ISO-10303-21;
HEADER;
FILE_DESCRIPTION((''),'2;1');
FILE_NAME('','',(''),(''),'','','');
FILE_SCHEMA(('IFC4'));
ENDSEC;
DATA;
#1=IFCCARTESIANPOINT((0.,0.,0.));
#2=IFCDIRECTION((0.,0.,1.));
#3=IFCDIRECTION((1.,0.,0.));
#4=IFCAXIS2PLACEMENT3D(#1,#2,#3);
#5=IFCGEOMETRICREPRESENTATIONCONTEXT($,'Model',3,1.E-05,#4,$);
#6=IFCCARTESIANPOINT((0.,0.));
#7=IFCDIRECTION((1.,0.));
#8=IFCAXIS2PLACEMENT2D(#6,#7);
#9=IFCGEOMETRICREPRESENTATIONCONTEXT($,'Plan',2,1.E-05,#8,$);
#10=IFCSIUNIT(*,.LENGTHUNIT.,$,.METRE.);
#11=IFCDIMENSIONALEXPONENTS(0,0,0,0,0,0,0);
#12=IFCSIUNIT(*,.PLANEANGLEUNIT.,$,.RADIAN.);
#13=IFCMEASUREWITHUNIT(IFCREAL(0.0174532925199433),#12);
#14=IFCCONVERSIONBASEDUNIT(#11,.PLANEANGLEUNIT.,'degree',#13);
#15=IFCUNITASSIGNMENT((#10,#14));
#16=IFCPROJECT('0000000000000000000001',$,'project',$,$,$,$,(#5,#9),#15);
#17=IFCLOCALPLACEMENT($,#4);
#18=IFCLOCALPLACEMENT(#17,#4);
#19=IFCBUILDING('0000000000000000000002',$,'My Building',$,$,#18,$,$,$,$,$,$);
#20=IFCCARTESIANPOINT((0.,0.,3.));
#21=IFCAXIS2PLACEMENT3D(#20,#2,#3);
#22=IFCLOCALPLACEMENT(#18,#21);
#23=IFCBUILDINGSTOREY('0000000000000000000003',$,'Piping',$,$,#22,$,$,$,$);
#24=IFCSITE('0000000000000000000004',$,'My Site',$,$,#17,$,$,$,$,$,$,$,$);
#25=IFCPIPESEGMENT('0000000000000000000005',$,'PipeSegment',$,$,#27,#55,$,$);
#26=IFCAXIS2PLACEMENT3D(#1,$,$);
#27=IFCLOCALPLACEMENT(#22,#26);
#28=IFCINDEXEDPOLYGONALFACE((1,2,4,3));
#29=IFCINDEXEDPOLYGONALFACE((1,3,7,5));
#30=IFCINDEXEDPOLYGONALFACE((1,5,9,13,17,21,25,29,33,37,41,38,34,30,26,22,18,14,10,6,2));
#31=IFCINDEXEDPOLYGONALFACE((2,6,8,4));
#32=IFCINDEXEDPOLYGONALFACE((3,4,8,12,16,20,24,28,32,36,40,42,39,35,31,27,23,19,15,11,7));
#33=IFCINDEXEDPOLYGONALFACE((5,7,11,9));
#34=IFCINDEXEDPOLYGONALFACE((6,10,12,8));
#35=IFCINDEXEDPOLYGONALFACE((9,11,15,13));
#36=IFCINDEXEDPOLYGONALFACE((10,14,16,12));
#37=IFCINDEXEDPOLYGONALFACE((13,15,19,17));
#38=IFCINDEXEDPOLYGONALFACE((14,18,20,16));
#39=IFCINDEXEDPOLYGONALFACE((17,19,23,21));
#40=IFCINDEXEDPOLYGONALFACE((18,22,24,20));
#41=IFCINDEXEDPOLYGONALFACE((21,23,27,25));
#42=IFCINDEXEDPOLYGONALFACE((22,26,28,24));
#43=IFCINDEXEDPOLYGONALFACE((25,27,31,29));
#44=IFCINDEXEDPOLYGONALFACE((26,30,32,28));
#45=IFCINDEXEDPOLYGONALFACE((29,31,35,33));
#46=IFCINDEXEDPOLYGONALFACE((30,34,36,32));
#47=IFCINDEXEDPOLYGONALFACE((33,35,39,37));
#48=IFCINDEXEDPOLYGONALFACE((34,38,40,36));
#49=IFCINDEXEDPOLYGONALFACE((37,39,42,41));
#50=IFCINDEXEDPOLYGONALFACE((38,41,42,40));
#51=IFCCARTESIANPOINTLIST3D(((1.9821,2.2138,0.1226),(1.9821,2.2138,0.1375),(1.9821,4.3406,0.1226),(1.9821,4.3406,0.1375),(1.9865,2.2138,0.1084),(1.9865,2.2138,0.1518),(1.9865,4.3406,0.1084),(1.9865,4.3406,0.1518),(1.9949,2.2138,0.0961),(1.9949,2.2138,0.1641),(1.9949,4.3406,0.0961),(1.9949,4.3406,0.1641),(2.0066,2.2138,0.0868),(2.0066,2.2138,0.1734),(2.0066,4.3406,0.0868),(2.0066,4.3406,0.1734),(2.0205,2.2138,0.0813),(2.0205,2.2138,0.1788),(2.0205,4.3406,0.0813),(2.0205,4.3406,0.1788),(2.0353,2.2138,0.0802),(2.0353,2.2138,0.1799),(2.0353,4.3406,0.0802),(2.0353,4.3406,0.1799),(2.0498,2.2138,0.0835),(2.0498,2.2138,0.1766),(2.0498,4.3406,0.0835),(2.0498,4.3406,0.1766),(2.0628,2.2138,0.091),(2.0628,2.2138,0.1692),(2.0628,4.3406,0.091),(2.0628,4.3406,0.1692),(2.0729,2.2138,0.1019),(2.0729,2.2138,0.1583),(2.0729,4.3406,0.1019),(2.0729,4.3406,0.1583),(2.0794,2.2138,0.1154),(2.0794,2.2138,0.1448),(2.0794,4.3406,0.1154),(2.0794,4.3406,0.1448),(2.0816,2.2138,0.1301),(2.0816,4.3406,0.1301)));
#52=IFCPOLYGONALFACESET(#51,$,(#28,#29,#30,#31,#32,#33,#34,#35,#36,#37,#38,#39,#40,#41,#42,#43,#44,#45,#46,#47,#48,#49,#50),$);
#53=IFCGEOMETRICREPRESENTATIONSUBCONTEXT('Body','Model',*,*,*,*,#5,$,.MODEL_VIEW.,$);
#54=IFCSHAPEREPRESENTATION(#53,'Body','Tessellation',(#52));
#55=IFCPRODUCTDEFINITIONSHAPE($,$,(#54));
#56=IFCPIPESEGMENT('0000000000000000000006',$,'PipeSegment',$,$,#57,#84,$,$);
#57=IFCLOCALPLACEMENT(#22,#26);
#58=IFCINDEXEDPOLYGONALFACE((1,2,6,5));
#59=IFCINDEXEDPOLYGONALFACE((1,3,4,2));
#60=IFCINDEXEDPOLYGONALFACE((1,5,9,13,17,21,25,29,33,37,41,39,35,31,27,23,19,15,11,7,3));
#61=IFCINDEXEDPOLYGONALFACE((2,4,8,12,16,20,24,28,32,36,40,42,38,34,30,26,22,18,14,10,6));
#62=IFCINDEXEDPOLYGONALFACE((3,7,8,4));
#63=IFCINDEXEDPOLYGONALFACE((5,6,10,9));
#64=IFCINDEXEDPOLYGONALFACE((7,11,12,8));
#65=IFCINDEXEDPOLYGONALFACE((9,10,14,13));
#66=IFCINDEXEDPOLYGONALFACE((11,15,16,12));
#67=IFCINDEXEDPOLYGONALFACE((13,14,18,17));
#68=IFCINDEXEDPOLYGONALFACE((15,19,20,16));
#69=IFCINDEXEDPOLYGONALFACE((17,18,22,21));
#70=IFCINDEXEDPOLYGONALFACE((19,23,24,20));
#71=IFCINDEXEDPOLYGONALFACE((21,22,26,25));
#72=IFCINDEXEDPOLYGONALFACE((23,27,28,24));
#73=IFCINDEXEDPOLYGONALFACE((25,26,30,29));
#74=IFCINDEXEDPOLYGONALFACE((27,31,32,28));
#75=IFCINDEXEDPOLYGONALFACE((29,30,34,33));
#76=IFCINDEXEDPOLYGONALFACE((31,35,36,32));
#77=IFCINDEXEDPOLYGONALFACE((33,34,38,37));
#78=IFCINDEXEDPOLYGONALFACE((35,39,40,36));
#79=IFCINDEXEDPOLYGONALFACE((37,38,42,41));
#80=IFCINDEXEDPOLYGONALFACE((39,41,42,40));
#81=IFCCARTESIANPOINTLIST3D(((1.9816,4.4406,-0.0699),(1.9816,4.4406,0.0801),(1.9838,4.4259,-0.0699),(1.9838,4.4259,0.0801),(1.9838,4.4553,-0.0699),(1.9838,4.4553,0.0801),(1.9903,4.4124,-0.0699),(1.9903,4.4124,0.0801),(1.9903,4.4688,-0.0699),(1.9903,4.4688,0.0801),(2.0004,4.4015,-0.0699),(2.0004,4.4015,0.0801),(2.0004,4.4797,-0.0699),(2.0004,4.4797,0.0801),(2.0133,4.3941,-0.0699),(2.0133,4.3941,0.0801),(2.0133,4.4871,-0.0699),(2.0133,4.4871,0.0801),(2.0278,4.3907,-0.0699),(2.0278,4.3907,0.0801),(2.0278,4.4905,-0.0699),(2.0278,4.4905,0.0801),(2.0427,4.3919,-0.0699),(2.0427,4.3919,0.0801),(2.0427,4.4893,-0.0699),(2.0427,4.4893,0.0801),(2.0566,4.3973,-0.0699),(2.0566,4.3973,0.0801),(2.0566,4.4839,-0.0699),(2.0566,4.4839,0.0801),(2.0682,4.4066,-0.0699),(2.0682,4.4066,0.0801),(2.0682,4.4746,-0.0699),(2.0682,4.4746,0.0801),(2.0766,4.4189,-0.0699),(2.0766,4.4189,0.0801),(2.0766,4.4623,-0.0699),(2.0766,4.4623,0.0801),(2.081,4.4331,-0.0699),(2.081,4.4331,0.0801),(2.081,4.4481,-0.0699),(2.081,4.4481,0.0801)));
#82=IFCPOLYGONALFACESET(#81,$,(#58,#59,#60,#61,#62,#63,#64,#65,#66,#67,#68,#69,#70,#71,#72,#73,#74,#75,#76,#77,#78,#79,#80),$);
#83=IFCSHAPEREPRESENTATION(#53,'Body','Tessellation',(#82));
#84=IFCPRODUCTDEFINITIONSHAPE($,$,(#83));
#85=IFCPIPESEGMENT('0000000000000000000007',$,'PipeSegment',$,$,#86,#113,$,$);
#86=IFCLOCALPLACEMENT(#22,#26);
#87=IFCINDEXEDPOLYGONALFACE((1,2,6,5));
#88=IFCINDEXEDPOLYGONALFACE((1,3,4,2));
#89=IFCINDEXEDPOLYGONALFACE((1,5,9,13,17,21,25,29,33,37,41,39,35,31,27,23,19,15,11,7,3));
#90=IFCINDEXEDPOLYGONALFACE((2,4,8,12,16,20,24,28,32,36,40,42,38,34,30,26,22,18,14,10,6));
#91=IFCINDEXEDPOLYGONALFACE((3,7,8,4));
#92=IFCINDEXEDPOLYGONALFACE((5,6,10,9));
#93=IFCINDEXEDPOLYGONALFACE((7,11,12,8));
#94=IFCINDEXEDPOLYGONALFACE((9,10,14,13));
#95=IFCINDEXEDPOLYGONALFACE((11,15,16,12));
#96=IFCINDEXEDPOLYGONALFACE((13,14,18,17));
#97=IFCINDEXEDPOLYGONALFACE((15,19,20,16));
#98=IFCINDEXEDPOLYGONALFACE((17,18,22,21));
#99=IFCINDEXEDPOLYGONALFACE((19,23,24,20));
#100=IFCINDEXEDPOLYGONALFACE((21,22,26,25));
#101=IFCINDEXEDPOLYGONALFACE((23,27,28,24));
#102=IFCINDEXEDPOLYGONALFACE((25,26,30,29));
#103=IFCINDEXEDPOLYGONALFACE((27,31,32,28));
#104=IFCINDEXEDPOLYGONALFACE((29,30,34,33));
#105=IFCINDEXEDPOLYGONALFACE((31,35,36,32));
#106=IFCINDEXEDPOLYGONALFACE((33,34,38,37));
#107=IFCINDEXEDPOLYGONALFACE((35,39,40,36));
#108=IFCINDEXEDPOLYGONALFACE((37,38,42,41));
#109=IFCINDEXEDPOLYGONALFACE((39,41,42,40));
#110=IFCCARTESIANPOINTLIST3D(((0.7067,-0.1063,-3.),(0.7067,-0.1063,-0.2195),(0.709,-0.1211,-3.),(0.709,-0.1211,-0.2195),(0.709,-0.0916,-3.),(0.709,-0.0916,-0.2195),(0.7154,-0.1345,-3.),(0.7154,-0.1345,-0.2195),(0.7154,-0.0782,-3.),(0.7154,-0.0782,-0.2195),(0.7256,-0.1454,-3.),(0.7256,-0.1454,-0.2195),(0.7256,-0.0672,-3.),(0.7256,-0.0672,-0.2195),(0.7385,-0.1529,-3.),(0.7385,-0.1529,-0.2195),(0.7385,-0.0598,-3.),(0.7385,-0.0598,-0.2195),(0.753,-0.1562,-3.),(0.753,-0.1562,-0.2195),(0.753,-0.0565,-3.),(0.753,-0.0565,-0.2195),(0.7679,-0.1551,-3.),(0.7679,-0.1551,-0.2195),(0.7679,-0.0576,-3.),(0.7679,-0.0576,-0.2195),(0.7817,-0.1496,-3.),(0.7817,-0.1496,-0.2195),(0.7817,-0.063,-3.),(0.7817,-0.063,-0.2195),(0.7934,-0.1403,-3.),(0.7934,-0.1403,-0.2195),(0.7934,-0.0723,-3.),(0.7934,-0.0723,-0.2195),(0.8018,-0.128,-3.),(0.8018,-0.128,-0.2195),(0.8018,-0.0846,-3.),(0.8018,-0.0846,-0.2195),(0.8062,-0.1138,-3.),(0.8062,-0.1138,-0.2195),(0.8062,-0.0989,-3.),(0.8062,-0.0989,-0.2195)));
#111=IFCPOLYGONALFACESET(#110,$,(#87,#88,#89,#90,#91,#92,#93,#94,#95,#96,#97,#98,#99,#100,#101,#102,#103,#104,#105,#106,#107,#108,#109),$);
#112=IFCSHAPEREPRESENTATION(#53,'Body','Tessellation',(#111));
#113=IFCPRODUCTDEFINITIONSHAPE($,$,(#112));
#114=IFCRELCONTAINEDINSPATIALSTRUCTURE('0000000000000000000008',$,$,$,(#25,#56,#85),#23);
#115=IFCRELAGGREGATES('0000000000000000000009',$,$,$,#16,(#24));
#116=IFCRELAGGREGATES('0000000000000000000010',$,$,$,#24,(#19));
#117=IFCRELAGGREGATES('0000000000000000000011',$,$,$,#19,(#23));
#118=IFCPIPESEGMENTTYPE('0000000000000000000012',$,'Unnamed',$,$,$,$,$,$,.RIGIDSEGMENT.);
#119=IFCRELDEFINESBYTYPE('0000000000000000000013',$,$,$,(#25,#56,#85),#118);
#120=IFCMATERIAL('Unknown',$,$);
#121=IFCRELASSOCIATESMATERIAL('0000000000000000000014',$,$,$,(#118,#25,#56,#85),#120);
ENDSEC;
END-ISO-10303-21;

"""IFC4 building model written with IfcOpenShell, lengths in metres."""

from ifc_helpers import new_model, entity, si_unit, converted_unit, frame, origin_with_axes, origin_2d_with_axis, place, context, subcontext, project, spatial, circle, extrude, material, material_profile, profile_set, profile_usage, type_object, element, save


model = new_model("IFC4")

# Units and contexts
model_context = context("Model", 3, precision=1e-05, world=origin_with_axes())
plan_context = context("Plan", 2, precision=1e-05, world=origin_2d_with_axis())
body_context = subcontext(model_context, "Body", "Model", "MODEL_VIEW")
ifc_project = project(units=[si_unit("LENGTHUNIT", "METRE"), converted_unit("PLANEANGLEUNIT", "degree", entity("IfcReal", 0.0174532925199433), si_unit("PLANEANGLEUNIT", "RADIAN"), dimensions=[0, 0, 0, 0, 0, 0, 0])], contexts=[model_context, plan_context])

# Site, building, storey
site_placement = place(None, origin_with_axes())
site = spatial("IfcSite", under=ifc_project, at=site_placement, Name="My Site")
building_placement = place(site_placement, origin_with_axes())
building = spatial("IfcBuilding", under=site, at=building_placement, Name="My Building")
storey_placement = place(building_placement, frame((0.0, 0.0, 3.0), z_axis=(0.0, 0.0, 1.0), x_axis=(1.0, 0.0, 0.0)))
storey = spatial("IfcBuildingStorey", under=building, at=storey_placement, Name="Piping")

# Pipe segments
ifc_material = material(Name="Unknown")
ifc_material_profile_1 = material_profile(ifc_material, circle(Radius=0.05))
ifc_profile_set_1 = profile_set([ifc_material_profile_1])
pipe_segment_type = type_object("IfcPipeSegmentType", Name="Unnamed", PredefinedType="RIGIDSEGMENT", material=ifc_profile_set_1)
ifc_profile_usage_1 = profile_usage(ifc_profile_set_1, cardinal=5)
pipe_segment_1_placement = place(storey_placement, frame((2.0316, 4.3406, 0.1301), z_axis=(0.0, -1.0, 0.0), x_axis=(1.0, 0.0, 0.0)))
element("IfcPipeSegment", 1, at=pipe_segment_1_placement, inside=storey, type_object=pipe_segment_type, material=ifc_profile_usage_1, Name="PipeSegment", context=body_context, shape_type="SweptSolid", body=[
    extrude(circle(Radius=0.05), origin_with_axes(), (0.0, 0.0, 1.0), 2.1268),
])
ifc_profile_usage_2 = profile_usage(ifc_profile_set_1, cardinal=5)
pipe_segment_2_placement = place(storey_placement, frame((2.0316, 4.4406, 0.0801), z_axis=(0.0, 0.0, -1.0), x_axis=(-1.0, 0.0, 0.0)))
element("IfcPipeSegment", 2, at=pipe_segment_2_placement, inside=storey, type_object=pipe_segment_type, material=ifc_profile_usage_2, Name="PipeSegment", context=body_context, shape_type="SweptSolid", body=[
    extrude(circle(Radius=0.05), origin_with_axes(), (0.0, 0.0, 1.0), 0.15),
])
ifc_profile_usage_3 = profile_usage(ifc_profile_set_1, cardinal=5)
pipe_segment_3_placement = place(storey_placement, frame((0.7567, -0.1063, -0.2195), z_axis=(0.0, 0.0, -1.0), x_axis=(-1.0, 0.0, 0.0)))
element("IfcPipeSegment", 3, at=pipe_segment_3_placement, inside=storey, type_object=pipe_segment_type, material=ifc_profile_usage_3, Name="PipeSegment", context=body_context, shape_type="SweptSolid", body=[
    extrude(circle(Radius=0.05), origin_with_axes(), (0.0, 0.0, 1.0), 2.7805),
])

save(model, "model.ifc")
